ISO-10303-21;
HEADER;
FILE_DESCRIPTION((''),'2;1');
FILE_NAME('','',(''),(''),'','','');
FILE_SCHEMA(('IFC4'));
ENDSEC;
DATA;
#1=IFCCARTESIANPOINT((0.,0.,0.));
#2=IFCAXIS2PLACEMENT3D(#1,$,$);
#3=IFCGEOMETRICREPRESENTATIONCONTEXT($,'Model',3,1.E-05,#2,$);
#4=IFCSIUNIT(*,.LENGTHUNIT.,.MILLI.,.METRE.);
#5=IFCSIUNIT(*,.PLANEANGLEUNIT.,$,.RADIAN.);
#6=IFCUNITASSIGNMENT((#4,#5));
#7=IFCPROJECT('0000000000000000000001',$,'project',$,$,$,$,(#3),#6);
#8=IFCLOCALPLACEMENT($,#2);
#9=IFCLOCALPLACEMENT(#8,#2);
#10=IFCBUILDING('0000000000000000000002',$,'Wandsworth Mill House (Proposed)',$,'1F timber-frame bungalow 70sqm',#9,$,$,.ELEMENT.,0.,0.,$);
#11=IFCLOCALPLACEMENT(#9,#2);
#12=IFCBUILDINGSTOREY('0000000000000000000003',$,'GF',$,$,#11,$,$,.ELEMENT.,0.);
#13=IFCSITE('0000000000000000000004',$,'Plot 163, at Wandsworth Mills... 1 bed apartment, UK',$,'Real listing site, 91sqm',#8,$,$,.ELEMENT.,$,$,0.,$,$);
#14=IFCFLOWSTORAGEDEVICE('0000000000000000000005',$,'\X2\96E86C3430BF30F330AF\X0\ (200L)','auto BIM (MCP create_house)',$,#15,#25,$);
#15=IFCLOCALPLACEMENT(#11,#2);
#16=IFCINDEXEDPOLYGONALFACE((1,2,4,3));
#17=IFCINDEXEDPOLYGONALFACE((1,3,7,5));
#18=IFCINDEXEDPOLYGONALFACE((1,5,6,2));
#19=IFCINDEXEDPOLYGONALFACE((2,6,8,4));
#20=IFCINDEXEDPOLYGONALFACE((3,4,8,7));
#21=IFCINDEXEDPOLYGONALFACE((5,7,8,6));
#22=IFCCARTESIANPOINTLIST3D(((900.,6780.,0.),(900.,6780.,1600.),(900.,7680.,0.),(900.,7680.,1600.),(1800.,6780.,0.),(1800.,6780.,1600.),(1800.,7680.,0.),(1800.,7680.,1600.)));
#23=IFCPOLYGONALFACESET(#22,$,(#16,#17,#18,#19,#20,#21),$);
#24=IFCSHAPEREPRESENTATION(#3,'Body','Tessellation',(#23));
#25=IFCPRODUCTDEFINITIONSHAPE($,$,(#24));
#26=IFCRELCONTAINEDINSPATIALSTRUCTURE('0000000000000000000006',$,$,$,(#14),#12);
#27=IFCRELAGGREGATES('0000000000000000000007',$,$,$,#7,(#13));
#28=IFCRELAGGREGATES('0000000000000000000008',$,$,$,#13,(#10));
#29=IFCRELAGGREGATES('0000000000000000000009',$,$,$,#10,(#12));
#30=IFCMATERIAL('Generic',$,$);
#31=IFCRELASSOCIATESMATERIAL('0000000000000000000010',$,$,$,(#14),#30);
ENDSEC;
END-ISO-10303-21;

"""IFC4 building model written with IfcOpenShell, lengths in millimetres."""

from ifc_helpers import new_model, si_unit, frame, frame_2d, origin, place, context, project, spatial, rectangle, extrude, material, element, save


model = new_model("IFC4")

# Units and contexts
model_context = context("Model", 3, precision=1e-05, world=origin())
ifc_project = project(units=[si_unit("LENGTHUNIT", "METRE", prefix="MILLI"), si_unit("PLANEANGLEUNIT", "RADIAN")], contexts=[model_context])

# Site, building, storey
site_placement = place(None, origin())
site = spatial("IfcSite", under=ifc_project, at=site_placement, Name="Plot 163, at Wandsworth Mills... 1 bed apartment, UK", ObjectType="Real listing site, 91sqm", CompositionType="ELEMENT", RefElevation=0.0)
building_placement = place(site_placement, origin())
building = spatial("IfcBuilding", under=site, at=building_placement, Name="Wandsworth Mill House (Proposed)", ObjectType="1F timber-frame bungalow 70sqm", CompositionType="ELEMENT", ElevationOfRefHeight=0.0, ElevationOfTerrain=0.0)
storey_placement = place(building_placement, origin())
storey = spatial("IfcBuildingStorey", under=building, at=storey_placement, Name="GF", CompositionType="ELEMENT", Elevation=0.0)

# Shared definitions
ifc_material_1 = material(Name="Generic")

# Flow storage device
flow_storage_device_placement = place(storey_placement, frame((450.0, 3390.0, 0.0)))
element("IfcFlowStorageDevice", 1, at=flow_storage_device_placement, inside=storey, material=ifc_material_1, Name="雨水タンク (200L)", Description="auto BIM (MCP create_house)", context=model_context, shape_type="SweptSolid", body=[
    extrude(rectangle(XDim=900.0, YDim=900.0, at=frame_2d((450.0, 450.0))), frame((450.0, 3390.0, 0.0)), (0.0, 0.0, 1.0), 1600.0),
])

save(model, "model.ifc")
